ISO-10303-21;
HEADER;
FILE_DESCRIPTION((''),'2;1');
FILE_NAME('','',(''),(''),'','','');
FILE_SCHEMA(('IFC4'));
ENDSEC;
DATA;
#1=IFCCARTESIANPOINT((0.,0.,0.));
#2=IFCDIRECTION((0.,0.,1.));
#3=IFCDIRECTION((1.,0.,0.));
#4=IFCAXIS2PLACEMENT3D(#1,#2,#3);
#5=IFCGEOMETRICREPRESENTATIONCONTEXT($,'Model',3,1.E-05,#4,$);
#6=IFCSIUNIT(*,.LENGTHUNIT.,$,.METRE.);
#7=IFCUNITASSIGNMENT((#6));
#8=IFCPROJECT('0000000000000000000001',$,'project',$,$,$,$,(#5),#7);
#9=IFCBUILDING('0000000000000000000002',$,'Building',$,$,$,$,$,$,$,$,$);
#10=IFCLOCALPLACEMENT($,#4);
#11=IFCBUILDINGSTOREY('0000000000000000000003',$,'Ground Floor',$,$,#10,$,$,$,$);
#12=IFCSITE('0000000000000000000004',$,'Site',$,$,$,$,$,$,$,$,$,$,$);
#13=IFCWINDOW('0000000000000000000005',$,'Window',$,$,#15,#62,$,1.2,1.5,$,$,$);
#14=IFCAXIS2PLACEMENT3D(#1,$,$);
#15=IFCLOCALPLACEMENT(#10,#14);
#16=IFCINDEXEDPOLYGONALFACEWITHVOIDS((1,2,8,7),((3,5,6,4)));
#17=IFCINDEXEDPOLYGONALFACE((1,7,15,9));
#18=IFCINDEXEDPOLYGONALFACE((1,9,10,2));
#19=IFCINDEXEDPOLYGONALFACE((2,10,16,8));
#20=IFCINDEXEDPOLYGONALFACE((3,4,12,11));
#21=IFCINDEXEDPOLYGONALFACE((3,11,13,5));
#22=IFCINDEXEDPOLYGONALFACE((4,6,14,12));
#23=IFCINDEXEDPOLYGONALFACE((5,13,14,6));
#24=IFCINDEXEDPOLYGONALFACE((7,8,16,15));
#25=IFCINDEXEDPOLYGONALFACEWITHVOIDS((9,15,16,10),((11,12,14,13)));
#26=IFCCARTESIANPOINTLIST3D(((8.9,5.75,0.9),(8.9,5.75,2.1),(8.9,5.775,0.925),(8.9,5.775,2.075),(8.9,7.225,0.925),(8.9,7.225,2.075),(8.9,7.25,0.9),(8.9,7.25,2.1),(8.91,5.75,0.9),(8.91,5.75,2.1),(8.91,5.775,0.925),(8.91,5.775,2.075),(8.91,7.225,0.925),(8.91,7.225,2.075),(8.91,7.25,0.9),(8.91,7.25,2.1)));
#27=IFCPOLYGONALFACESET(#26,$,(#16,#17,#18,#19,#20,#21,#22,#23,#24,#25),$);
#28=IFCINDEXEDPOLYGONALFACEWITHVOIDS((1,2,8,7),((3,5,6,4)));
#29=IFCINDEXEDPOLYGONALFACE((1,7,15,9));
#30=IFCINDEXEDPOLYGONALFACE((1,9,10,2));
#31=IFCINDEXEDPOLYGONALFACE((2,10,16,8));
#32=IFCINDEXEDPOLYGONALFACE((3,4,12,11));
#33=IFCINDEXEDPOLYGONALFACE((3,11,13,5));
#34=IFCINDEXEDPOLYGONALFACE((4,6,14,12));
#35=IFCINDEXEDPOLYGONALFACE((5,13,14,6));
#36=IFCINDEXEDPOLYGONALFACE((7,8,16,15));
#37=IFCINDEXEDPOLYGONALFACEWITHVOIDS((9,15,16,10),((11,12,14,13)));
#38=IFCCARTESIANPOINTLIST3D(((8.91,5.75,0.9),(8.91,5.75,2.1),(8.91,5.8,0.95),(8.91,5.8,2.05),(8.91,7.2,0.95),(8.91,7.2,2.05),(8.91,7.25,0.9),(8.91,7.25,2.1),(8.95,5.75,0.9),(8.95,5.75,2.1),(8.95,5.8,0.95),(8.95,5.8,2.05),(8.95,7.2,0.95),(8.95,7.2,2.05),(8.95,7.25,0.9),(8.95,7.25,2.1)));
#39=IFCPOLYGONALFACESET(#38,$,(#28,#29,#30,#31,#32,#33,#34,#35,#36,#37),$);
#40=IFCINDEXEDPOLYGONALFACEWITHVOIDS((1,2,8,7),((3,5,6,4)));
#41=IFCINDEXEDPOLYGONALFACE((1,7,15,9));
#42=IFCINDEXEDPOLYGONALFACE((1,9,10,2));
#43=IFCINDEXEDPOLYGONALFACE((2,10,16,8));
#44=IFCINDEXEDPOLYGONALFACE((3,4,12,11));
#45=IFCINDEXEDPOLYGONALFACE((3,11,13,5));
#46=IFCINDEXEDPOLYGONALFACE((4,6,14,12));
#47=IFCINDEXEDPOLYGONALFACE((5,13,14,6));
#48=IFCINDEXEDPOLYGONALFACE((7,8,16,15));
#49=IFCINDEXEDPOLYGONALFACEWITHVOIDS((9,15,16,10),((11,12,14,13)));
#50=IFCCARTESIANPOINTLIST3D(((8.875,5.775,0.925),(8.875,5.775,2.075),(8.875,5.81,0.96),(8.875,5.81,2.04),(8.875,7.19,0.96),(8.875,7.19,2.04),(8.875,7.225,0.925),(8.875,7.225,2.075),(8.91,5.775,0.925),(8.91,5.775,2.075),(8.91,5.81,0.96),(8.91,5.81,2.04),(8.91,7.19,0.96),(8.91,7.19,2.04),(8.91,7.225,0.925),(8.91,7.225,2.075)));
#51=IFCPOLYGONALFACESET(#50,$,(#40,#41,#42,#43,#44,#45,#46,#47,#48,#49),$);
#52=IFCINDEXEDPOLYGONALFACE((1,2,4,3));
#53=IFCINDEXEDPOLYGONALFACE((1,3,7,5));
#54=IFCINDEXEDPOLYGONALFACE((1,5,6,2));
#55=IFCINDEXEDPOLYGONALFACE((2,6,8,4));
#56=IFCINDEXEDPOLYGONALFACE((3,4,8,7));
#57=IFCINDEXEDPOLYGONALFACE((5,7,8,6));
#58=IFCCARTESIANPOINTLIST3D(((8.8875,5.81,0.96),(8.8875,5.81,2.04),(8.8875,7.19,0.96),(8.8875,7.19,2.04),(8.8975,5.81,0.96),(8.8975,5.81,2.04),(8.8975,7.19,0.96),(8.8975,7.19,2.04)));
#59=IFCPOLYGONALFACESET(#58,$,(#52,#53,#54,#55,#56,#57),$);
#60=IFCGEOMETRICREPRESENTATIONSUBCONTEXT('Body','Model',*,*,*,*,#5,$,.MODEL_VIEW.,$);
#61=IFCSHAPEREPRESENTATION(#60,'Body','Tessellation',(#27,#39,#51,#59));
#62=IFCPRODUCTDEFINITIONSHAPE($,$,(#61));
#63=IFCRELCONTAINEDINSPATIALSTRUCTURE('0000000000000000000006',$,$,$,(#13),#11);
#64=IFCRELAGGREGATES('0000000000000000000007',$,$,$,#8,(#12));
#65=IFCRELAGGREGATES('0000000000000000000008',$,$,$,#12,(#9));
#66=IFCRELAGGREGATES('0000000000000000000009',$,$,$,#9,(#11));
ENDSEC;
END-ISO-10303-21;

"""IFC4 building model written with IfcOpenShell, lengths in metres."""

from ifc_helpers import new_model, si_unit, frame, origin_with_axes, place, context, subcontext, project, spatial, line, indexed_curve, outline, extrude, element, save


model = new_model("IFC4")

# Units and contexts
model_context = context("Model", 3, precision=1e-05, world=origin_with_axes())
body_context = subcontext(model_context, "Body", "Model", "MODEL_VIEW")
ifc_project = project(units=[si_unit("LENGTHUNIT", "METRE")], contexts=[model_context])

# Site, building, storey
site = spatial("IfcSite", under=ifc_project, Name="Site")
building = spatial("IfcBuilding", under=site, Name="Building")
storey_placement = place(None, origin_with_axes())
storey = spatial("IfcBuildingStorey", under=building, at=storey_placement, Name="Ground Floor")

# Window
for number, where, z_axis, x_axis, name in (
    (1, (9.0, 5.75, 0.9), (0.0, 0.0, 1.0), (0.0, 1.0, 0.0), "Window"),
):
    element("IfcWindow", number, at=place(storey_placement, frame(where, z_axis=z_axis, x_axis=x_axis)), inside=storey, Name=name, OverallHeight=1.2, OverallWidth=1.5, context=body_context, shape_type="SweptSolid", body=[
        extrude(outline(indexed_curve([(0.0, 0.0), (1.5, 0.0), (1.5, 1.2), (0.0, 1.2)], segments=[line(1, 2, 3, 4, 1)]), holes=[indexed_curve([(0.025, 0.025), (1.475, 0.025), (1.475, 1.175), (0.025, 1.175)], segments=[line(1, 2, 3, 4, 1)])]), frame((0.0, 0.09, 0.0), z_axis=(0.0, -1.0, 0.0), x_axis=(1.0, 0.0, 0.0)), (0.0, 0.0, -1.0), 0.01),
        extrude(outline(indexed_curve([(0.0, 0.0), (1.5, 0.0), (1.5, 1.2), (0.0, 1.2)], segments=[line(1, 2, 3, 4, 1)]), holes=[indexed_curve([(0.05, 0.05), (1.45, 0.05), (1.45, 1.15), (0.05, 1.15)], segments=[line(1, 2, 3, 4, 1)])]), frame((0.0, 0.05, 0.0), z_axis=(0.0, -1.0, 0.0), x_axis=(1.0, 0.0, 0.0)), (0.0, 0.0, -1.0), 0.04),
        extrude(outline(indexed_curve([(0.0, 0.0), (1.45, 0.0), (1.45, 1.15), (0.0, 1.15)], segments=[line(1, 2, 3, 4, 1)]), holes=[indexed_curve([(0.035, 0.035), (1.415, 0.035), (1.415, 1.115), (0.035, 1.115)], segments=[line(1, 2, 3, 4, 1)])]), frame((0.025, 0.09, 0.025), z_axis=(0.0, -1.0, 0.0), x_axis=(1.0, 0.0, 0.0)), (0.0, 0.0, -1.0), 0.035),
        extrude(outline(indexed_curve([(0.035, 0.035), (1.415, 0.035), (1.415, 1.115), (0.035, 1.115)], segments=[line(1, 2, 3, 4, 1)])), frame((0.025, 0.1025, 0.025), z_axis=(0.0, -1.0, 0.0), x_axis=(1.0, 0.0, 0.0)), (0.0, 0.0, -1.0), 0.01),
    ])

save(model, "model.ifc")
